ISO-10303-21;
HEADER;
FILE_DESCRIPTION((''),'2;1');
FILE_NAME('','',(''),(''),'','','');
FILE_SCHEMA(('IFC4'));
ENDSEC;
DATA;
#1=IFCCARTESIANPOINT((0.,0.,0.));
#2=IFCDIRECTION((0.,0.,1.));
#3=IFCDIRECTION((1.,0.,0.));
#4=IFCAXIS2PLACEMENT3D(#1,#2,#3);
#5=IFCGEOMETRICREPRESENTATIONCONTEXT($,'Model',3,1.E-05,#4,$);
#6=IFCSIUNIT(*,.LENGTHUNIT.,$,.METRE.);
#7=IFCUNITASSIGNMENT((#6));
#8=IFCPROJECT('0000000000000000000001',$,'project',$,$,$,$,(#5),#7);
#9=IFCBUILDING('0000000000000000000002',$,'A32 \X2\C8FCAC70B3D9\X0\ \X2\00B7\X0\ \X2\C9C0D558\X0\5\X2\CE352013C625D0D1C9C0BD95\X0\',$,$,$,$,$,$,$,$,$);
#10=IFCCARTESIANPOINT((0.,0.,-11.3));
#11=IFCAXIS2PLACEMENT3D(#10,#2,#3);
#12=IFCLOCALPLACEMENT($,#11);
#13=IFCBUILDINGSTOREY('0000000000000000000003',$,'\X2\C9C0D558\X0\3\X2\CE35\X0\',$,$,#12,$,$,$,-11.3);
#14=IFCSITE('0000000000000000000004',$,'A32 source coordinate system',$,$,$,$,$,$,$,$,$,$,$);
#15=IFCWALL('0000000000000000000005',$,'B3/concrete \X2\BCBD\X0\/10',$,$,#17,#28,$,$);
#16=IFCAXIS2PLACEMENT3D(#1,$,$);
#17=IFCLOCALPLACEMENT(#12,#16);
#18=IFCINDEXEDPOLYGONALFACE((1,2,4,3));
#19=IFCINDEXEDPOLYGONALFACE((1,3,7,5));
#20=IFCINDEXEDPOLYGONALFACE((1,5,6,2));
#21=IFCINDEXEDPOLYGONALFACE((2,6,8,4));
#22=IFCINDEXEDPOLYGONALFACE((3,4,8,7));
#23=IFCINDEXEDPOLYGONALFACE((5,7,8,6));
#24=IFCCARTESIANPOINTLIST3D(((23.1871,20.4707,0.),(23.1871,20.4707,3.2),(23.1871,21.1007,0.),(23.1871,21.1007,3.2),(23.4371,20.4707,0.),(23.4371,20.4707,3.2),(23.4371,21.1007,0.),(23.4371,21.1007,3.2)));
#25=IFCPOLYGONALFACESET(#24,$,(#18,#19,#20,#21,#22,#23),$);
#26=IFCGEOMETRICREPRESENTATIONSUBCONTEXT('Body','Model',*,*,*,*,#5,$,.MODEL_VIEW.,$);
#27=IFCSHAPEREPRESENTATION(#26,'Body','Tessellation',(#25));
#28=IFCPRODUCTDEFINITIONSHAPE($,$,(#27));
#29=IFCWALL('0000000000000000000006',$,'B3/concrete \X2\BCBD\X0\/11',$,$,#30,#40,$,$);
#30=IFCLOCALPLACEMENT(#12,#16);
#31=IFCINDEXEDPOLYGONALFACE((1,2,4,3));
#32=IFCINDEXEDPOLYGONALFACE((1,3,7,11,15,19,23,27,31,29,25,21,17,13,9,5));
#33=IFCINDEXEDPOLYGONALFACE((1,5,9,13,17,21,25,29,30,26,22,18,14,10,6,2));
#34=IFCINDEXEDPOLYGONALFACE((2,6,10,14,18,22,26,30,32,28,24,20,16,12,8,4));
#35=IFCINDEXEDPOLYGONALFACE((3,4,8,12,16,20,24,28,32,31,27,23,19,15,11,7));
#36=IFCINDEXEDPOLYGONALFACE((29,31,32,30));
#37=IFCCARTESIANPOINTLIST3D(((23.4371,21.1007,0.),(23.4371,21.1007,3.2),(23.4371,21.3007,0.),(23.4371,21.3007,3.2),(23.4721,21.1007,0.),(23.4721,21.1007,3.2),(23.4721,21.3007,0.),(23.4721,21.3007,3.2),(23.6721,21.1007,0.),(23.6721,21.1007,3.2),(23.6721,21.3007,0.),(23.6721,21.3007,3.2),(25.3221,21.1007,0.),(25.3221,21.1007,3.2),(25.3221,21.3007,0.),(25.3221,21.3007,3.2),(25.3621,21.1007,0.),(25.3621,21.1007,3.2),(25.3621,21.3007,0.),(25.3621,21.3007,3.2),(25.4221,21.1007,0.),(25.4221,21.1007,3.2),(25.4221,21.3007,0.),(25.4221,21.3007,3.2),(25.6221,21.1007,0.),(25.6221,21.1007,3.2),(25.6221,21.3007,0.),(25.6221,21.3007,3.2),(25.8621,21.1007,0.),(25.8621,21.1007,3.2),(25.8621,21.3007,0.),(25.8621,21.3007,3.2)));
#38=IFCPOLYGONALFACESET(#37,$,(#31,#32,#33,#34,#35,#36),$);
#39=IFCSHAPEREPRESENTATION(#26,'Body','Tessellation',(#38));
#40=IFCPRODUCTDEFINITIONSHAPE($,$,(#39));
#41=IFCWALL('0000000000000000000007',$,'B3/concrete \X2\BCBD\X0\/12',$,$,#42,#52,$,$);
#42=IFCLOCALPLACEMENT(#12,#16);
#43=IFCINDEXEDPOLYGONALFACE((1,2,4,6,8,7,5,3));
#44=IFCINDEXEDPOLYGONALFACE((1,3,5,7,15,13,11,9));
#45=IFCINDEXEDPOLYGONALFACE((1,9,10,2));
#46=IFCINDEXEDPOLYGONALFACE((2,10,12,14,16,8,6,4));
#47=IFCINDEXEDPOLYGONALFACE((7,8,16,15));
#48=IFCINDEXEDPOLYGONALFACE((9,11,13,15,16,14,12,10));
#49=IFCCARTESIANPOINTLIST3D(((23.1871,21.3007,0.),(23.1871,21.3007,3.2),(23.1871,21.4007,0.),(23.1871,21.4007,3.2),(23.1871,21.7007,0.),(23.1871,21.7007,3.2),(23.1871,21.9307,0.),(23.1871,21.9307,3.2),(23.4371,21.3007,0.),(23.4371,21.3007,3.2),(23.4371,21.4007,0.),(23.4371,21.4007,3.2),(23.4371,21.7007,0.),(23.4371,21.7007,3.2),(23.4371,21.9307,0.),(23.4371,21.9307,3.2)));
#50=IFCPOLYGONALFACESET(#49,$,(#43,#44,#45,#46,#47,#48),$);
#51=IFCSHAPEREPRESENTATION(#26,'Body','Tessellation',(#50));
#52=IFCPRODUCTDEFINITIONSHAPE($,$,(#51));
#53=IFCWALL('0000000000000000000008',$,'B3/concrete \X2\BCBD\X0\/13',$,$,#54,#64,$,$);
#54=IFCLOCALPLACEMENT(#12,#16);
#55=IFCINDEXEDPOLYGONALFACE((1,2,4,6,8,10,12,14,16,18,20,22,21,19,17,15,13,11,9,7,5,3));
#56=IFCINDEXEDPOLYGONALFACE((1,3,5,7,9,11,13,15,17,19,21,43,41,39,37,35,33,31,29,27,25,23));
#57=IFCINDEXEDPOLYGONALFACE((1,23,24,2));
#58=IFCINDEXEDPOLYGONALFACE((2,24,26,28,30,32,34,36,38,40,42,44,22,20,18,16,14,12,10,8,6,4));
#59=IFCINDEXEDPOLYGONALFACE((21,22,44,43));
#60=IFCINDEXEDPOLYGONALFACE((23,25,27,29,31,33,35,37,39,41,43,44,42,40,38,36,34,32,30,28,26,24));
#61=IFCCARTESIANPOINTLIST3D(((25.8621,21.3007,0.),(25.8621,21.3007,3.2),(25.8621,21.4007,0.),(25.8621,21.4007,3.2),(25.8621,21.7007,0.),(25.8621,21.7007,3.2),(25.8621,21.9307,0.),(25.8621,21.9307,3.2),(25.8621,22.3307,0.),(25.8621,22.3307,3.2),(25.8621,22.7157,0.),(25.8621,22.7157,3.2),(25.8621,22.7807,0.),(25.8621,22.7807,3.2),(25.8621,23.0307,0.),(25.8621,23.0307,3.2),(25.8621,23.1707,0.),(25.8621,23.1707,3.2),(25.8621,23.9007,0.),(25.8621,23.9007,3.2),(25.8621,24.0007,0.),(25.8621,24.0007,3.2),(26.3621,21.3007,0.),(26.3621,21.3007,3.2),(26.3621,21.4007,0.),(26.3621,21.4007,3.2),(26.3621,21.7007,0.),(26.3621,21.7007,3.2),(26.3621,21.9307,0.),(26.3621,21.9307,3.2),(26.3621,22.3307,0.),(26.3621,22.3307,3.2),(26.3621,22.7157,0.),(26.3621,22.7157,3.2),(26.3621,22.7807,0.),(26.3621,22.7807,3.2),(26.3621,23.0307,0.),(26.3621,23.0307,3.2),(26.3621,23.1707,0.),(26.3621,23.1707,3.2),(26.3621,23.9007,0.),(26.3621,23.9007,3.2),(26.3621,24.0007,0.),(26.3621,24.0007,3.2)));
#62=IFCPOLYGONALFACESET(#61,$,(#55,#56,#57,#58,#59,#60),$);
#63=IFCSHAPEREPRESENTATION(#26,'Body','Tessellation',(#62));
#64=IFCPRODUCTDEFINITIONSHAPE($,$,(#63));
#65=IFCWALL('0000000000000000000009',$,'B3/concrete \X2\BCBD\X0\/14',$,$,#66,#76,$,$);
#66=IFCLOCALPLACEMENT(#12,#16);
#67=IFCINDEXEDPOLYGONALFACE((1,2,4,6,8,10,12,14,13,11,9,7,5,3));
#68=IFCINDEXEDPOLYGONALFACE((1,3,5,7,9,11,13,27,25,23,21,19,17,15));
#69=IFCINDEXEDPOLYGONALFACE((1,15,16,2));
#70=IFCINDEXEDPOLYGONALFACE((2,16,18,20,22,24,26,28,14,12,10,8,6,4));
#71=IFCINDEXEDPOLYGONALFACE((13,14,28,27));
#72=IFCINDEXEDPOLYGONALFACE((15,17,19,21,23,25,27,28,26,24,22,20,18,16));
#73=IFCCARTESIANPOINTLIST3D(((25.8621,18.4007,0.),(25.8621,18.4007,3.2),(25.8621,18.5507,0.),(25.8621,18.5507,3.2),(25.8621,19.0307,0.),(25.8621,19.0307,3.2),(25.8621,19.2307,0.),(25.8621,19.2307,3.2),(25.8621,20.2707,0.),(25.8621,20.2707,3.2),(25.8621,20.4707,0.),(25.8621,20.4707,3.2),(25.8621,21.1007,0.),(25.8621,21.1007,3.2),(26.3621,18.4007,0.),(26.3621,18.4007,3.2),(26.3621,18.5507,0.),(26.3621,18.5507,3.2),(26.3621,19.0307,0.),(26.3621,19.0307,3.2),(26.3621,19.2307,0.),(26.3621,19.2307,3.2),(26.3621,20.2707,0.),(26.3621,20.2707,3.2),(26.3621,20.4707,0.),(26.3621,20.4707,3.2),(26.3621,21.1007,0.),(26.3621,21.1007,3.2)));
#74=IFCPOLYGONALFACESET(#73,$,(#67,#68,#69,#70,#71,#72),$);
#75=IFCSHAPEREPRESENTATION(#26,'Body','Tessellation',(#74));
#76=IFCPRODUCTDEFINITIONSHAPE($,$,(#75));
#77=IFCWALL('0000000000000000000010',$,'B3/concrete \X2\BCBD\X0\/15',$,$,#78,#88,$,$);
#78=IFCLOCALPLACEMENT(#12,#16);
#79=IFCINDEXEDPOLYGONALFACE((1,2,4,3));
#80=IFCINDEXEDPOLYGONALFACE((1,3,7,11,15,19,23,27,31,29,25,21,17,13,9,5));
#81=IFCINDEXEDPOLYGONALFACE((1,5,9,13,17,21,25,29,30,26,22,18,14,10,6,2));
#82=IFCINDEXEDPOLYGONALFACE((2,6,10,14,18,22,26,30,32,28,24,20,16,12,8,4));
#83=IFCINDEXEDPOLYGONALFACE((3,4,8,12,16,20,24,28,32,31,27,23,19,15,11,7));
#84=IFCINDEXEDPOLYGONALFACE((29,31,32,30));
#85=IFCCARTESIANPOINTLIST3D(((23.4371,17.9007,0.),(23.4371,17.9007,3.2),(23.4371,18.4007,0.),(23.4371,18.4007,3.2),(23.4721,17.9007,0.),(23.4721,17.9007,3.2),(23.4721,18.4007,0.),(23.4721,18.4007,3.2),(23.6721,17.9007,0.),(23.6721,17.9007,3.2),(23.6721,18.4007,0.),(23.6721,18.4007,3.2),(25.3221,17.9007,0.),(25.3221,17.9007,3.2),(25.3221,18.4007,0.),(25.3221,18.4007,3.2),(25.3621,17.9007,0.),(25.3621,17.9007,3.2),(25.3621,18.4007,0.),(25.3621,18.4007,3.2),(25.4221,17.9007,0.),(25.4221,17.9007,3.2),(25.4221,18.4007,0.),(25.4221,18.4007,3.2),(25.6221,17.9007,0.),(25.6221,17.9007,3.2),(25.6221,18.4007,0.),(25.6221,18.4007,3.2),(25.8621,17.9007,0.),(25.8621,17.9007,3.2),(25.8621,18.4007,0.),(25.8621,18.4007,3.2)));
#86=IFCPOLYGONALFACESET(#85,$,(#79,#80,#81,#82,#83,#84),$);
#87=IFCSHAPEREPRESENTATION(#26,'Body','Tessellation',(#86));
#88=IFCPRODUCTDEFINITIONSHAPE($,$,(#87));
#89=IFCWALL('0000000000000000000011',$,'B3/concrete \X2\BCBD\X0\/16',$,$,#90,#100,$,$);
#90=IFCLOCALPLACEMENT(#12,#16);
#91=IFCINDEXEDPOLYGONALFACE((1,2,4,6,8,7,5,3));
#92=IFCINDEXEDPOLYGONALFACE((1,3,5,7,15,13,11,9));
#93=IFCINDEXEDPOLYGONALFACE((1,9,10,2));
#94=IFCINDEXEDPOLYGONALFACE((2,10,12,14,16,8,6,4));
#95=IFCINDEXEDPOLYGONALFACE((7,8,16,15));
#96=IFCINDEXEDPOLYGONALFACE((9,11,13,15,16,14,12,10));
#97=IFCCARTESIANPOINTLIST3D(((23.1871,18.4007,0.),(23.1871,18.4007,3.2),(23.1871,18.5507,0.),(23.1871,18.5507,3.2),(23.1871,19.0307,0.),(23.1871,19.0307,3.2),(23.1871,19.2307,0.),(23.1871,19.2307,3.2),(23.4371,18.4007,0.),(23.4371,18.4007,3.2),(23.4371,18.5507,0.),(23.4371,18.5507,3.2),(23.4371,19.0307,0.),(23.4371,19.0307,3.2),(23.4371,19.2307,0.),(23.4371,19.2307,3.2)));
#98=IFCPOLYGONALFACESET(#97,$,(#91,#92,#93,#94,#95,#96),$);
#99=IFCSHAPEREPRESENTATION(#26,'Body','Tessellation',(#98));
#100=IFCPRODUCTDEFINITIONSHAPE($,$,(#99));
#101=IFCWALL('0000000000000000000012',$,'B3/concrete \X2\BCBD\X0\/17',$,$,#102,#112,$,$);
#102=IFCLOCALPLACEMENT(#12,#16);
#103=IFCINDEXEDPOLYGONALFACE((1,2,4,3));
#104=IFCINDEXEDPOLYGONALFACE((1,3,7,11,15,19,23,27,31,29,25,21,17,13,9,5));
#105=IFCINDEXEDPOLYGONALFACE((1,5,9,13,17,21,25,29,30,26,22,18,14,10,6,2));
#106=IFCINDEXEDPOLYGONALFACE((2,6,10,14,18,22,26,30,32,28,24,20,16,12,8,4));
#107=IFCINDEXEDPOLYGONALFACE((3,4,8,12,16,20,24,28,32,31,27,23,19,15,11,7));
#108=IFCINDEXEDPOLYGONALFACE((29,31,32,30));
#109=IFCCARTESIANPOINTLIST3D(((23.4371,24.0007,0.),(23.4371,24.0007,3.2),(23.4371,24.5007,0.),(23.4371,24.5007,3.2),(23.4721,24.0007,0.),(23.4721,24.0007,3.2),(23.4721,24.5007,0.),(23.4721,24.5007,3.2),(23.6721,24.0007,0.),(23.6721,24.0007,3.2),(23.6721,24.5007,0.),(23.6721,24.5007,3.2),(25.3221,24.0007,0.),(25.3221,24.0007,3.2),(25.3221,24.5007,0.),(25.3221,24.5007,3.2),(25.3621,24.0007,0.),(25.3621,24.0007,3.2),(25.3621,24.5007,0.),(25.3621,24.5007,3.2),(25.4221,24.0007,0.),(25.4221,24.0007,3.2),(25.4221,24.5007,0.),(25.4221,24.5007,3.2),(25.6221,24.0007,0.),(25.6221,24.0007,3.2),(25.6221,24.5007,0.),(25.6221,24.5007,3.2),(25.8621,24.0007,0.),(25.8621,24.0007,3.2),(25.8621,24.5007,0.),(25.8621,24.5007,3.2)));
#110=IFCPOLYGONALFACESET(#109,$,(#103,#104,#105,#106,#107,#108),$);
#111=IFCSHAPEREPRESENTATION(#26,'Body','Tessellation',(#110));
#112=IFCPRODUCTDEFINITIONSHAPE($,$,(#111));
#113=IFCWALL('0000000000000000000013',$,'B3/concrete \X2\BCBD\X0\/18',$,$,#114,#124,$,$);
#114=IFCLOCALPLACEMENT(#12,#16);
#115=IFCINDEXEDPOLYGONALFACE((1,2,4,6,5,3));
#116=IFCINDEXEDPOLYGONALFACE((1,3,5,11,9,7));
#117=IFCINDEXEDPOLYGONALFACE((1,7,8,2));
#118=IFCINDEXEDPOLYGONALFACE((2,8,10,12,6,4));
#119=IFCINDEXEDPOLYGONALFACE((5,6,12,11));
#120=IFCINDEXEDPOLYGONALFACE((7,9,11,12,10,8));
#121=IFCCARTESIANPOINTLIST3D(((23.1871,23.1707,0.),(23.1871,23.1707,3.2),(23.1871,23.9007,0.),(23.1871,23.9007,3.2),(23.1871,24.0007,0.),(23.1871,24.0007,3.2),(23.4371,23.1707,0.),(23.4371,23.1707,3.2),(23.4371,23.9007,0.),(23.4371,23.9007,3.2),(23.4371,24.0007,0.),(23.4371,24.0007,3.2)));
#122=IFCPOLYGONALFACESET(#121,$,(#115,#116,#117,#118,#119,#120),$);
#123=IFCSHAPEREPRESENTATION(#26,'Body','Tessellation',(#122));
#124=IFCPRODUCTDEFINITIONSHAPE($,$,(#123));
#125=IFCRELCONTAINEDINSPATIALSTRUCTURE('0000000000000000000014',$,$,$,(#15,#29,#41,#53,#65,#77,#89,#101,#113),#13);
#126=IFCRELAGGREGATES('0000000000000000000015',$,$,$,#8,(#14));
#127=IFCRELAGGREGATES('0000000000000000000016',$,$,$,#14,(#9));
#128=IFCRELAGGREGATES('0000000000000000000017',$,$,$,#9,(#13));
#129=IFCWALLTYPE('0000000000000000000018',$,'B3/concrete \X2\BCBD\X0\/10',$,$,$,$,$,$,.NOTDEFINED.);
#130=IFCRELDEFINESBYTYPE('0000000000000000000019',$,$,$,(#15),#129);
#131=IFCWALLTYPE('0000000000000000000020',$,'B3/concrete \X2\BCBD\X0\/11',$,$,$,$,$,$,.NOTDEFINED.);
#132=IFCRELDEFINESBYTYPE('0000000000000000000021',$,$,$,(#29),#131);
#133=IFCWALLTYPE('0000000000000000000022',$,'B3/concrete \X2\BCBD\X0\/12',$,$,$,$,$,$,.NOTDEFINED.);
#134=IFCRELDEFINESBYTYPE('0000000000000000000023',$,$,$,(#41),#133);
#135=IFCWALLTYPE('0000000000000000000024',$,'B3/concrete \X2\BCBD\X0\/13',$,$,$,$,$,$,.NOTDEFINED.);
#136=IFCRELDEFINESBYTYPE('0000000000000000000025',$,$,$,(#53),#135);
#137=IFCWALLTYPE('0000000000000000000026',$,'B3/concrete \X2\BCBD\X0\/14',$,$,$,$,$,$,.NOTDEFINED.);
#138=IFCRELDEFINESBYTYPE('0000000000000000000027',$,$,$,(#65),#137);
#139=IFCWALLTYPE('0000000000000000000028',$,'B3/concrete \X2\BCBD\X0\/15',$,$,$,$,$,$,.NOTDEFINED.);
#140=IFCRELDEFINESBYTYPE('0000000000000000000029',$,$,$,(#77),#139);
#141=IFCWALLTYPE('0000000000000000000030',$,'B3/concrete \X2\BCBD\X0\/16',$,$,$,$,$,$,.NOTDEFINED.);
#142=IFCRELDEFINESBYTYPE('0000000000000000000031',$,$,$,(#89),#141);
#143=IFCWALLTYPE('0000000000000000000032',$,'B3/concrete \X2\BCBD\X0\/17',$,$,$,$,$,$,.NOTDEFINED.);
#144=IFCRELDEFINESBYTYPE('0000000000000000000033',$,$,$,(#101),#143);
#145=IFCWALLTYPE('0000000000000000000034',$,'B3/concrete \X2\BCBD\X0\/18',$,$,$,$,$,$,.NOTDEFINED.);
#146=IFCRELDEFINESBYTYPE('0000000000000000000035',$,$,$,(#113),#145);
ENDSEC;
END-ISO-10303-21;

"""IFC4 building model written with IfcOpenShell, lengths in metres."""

from ifc_helpers import new_model, si_unit, frame, origin, origin_with_axes, place, context, subcontext, project, spatial, polyline, outline, extrude, source, transform, mapped, type_object, type_shapes, element, save


model = new_model("IFC4")

# Units and contexts
model_context = context("Model", 3, precision=1e-05, world=origin_with_axes())
body_context = subcontext(model_context, "Body", "Model", "MODEL_VIEW")
ifc_project = project(units=[si_unit("LENGTHUNIT", "METRE")], contexts=[model_context])

# Site, building, storey
site = spatial("IfcSite", under=ifc_project, Name="A32 source coordinate system")
building = spatial("IfcBuilding", under=site, Name="A32 주거동 · 지하5층–옥탑지붕")
storey_placement = place(None, frame((0.0, 0.0, -11.3), z_axis=(0.0, 0.0, 1.0), x_axis=(1.0, 0.0, 0.0)))
storey = spatial("IfcBuildingStorey", under=building, at=storey_placement, Name="지하3층", Elevation=-11.3)

# Walls
wall_type_1 = type_object("IfcWallType", Name="B3/concrete 벽/10", PredefinedType="NOTDEFINED")
shared_shape_1 = source(origin(), body_context, "Body", "SweptSolid", [
    extrude(outline(polyline([(23.1871, 20.4707), (23.1871, 21.1007), (23.4371, 21.1007), (23.4371, 20.4707), (23.1871, 20.4707)])), origin(), (0.0, 0.0, 1.0), 3.2),
])
type_shapes(wall_type_1, [shared_shape_1])
wall_1_placement = place(storey_placement, origin_with_axes())
element("IfcWall", 1, at=wall_1_placement, inside=storey, type_object=wall_type_1, Name="B3/concrete 벽/10", context=body_context, shape_type="MappedRepresentation", body=[
    mapped(shared_shape_1, transform((0.0, 0.0, 0.0), scale=1.0)),
])
wall_type_2 = type_object("IfcWallType", Name="B3/concrete 벽/11", PredefinedType="NOTDEFINED")
shared_shape_2 = source(origin(), body_context, "Body", "SweptSolid", [
    extrude(outline(polyline([(23.6721, 21.3007), (25.3221, 21.3007), (25.3621, 21.3007), (25.4221, 21.3007), (25.6221, 21.3007), (25.8621, 21.3007), (25.8621, 21.1007), (25.6221, 21.1007), (25.4221, 21.1007), (25.3621, 21.1007), (25.3221, 21.1007), (23.6721, 21.1007), (23.4721, 21.1007), (23.4371, 21.1007), (23.4371, 21.3007), (23.4721, 21.3007), (23.6721, 21.3007)])), origin(), (0.0, 0.0, 1.0), 3.2),
])
type_shapes(wall_type_2, [shared_shape_2])
wall_2_placement = place(storey_placement, origin_with_axes())
element("IfcWall", 2, at=wall_2_placement, inside=storey, type_object=wall_type_2, Name="B3/concrete 벽/11", context=body_context, shape_type="MappedRepresentation", body=[
    mapped(shared_shape_2, transform((0.0, 0.0, 0.0), scale=1.0)),
])
wall_type_3 = type_object("IfcWallType", Name="B3/concrete 벽/12", PredefinedType="NOTDEFINED")
shared_shape_3 = source(origin(), body_context, "Body", "SweptSolid", [
    extrude(outline(polyline([(23.1871, 21.7007), (23.1871, 21.9307), (23.4371, 21.9307), (23.4371, 21.7007), (23.4371, 21.4007), (23.4371, 21.3007), (23.1871, 21.3007), (23.1871, 21.4007), (23.1871, 21.7007)])), origin(), (0.0, 0.0, 1.0), 3.2),
])
type_shapes(wall_type_3, [shared_shape_3])
wall_3_placement = place(storey_placement, origin_with_axes())
element("IfcWall", 3, at=wall_3_placement, inside=storey, type_object=wall_type_3, Name="B3/concrete 벽/12", context=body_context, shape_type="MappedRepresentation", body=[
    mapped(shared_shape_3, transform((0.0, 0.0, 0.0), scale=1.0)),
])
wall_type_4 = type_object("IfcWallType", Name="B3/concrete 벽/13", PredefinedType="NOTDEFINED")
shared_shape_4 = source(origin(), body_context, "Body", "SweptSolid", [
    extrude(outline(polyline([(25.8621, 21.9307), (25.8621, 22.3307), (25.8621, 22.7157), (25.8621, 22.7807), (25.8621, 23.0307), (25.8621, 23.1707), (25.8621, 23.9007), (25.8621, 24.0007), (26.3621, 24.0007), (26.3621, 23.9007), (26.3621, 23.1707), (26.3621, 23.0307), (26.3621, 22.7807), (26.3621, 22.7157), (26.3621, 22.3307), (26.3621, 21.9307), (26.3621, 21.7007), (26.3621, 21.4007), (26.3621, 21.3007), (25.8621, 21.3007), (25.8621, 21.4007), (25.8621, 21.7007), (25.8621, 21.9307)])), origin(), (0.0, 0.0, 1.0), 3.2),
])
type_shapes(wall_type_4, [shared_shape_4])
wall_4_placement = place(storey_placement, origin_with_axes())
element("IfcWall", 4, at=wall_4_placement, inside=storey, type_object=wall_type_4, Name="B3/concrete 벽/13", context=body_context, shape_type="MappedRepresentation", body=[
    mapped(shared_shape_4, transform((0.0, 0.0, 0.0), scale=1.0)),
])
wall_type_5 = type_object("IfcWallType", Name="B3/concrete 벽/14", PredefinedType="NOTDEFINED")
shared_shape_5 = source(origin(), body_context, "Body", "SweptSolid", [
    extrude(outline(polyline([(26.3621, 20.2707), (26.3621, 19.2307), (26.3621, 19.0307), (26.3621, 18.5507), (26.3621, 18.4007), (25.8621, 18.4007), (25.8621, 18.5507), (25.8621, 19.0307), (25.8621, 19.2307), (25.8621, 20.2707), (25.8621, 20.4707), (25.8621, 21.1007), (26.3621, 21.1007), (26.3621, 20.4707), (26.3621, 20.2707)])), origin(), (0.0, 0.0, 1.0), 3.2),
])
type_shapes(wall_type_5, [shared_shape_5])
wall_5_placement = place(storey_placement, origin_with_axes())
element("IfcWall", 5, at=wall_5_placement, inside=storey, type_object=wall_type_5, Name="B3/concrete 벽/14", context=body_context, shape_type="MappedRepresentation", body=[
    mapped(shared_shape_5, transform((0.0, 0.0, 0.0), scale=1.0)),
])
wall_type_6 = type_object("IfcWallType", Name="B3/concrete 벽/15", PredefinedType="NOTDEFINED")
shared_shape_6 = source(origin(), body_context, "Body", "SweptSolid", [
    extrude(outline(polyline([(25.4221, 17.9007), (25.3621, 17.9007), (25.3221, 17.9007), (23.6721, 17.9007), (23.4721, 17.9007), (23.4371, 17.9007), (23.4371, 18.4007), (23.4721, 18.4007), (23.6721, 18.4007), (25.3221, 18.4007), (25.3621, 18.4007), (25.4221, 18.4007), (25.6221, 18.4007), (25.8621, 18.4007), (25.8621, 17.9007), (25.6221, 17.9007), (25.4221, 17.9007)])), origin(), (0.0, 0.0, 1.0), 3.2),
])
type_shapes(wall_type_6, [shared_shape_6])
wall_6_placement = place(storey_placement, origin_with_axes())
element("IfcWall", 6, at=wall_6_placement, inside=storey, type_object=wall_type_6, Name="B3/concrete 벽/15", context=body_context, shape_type="MappedRepresentation", body=[
    mapped(shared_shape_6, transform((0.0, 0.0, 0.0), scale=1.0)),
])
wall_type_7 = type_object("IfcWallType", Name="B3/concrete 벽/16", PredefinedType="NOTDEFINED")
shared_shape_7 = source(origin(), body_context, "Body", "SweptSolid", [
    extrude(outline(polyline([(23.1871, 19.0307), (23.1871, 19.2307), (23.4371, 19.2307), (23.4371, 19.0307), (23.4371, 18.5507), (23.4371, 18.4007), (23.1871, 18.4007), (23.1871, 18.5507), (23.1871, 19.0307)])), origin(), (0.0, 0.0, 1.0), 3.2),
])
type_shapes(wall_type_7, [shared_shape_7])
wall_7_placement = place(storey_placement, origin_with_axes())
element("IfcWall", 7, at=wall_7_placement, inside=storey, type_object=wall_type_7, Name="B3/concrete 벽/16", context=body_context, shape_type="MappedRepresentation", body=[
    mapped(shared_shape_7, transform((0.0, 0.0, 0.0), scale=1.0)),
])
wall_type_8 = type_object("IfcWallType", Name="B3/concrete 벽/17", PredefinedType="NOTDEFINED")
shared_shape_8 = source(origin(), body_context, "Body", "SweptSolid", [
    extrude(outline(polyline([(25.3621, 24.0007), (25.3221, 24.0007), (23.6721, 24.0007), (23.4721, 24.0007), (23.4371, 24.0007), (23.4371, 24.5007), (23.4721, 24.5007), (23.6721, 24.5007), (25.3221, 24.5007), (25.3621, 24.5007), (25.4221, 24.5007), (25.6221, 24.5007), (25.8621, 24.5007), (25.8621, 24.0007), (25.6221, 24.0007), (25.4221, 24.0007), (25.3621, 24.0007)])), origin(), (0.0, 0.0, 1.0), 3.2),
])
type_shapes(wall_type_8, [shared_shape_8])
wall_8_placement = place(storey_placement, origin_with_axes())
element("IfcWall", 8, at=wall_8_placement, inside=storey, type_object=wall_type_8, Name="B3/concrete 벽/17", context=body_context, shape_type="MappedRepresentation", body=[
    mapped(shared_shape_8, transform((0.0, 0.0, 0.0), scale=1.0)),
])
wall_type_9 = type_object("IfcWallType", Name="B3/concrete 벽/18", PredefinedType="NOTDEFINED")
shared_shape_9 = source(origin(), body_context, "Body", "SweptSolid", [
    extrude(outline(polyline([(23.1871, 23.1707), (23.1871, 23.9007), (23.1871, 24.0007), (23.4371, 24.0007), (23.4371, 23.9007), (23.4371, 23.1707), (23.1871, 23.1707)])), origin(), (0.0, 0.0, 1.0), 3.2),
])
type_shapes(wall_type_9, [shared_shape_9])
wall_9_placement = place(storey_placement, origin_with_axes())
element("IfcWall", 9, at=wall_9_placement, inside=storey, type_object=wall_type_9, Name="B3/concrete 벽/18", context=body_context, shape_type="MappedRepresentation", body=[
    mapped(shared_shape_9, transform((0.0, 0.0, 0.0), scale=1.0)),
])

save(model, "model.ifc")
